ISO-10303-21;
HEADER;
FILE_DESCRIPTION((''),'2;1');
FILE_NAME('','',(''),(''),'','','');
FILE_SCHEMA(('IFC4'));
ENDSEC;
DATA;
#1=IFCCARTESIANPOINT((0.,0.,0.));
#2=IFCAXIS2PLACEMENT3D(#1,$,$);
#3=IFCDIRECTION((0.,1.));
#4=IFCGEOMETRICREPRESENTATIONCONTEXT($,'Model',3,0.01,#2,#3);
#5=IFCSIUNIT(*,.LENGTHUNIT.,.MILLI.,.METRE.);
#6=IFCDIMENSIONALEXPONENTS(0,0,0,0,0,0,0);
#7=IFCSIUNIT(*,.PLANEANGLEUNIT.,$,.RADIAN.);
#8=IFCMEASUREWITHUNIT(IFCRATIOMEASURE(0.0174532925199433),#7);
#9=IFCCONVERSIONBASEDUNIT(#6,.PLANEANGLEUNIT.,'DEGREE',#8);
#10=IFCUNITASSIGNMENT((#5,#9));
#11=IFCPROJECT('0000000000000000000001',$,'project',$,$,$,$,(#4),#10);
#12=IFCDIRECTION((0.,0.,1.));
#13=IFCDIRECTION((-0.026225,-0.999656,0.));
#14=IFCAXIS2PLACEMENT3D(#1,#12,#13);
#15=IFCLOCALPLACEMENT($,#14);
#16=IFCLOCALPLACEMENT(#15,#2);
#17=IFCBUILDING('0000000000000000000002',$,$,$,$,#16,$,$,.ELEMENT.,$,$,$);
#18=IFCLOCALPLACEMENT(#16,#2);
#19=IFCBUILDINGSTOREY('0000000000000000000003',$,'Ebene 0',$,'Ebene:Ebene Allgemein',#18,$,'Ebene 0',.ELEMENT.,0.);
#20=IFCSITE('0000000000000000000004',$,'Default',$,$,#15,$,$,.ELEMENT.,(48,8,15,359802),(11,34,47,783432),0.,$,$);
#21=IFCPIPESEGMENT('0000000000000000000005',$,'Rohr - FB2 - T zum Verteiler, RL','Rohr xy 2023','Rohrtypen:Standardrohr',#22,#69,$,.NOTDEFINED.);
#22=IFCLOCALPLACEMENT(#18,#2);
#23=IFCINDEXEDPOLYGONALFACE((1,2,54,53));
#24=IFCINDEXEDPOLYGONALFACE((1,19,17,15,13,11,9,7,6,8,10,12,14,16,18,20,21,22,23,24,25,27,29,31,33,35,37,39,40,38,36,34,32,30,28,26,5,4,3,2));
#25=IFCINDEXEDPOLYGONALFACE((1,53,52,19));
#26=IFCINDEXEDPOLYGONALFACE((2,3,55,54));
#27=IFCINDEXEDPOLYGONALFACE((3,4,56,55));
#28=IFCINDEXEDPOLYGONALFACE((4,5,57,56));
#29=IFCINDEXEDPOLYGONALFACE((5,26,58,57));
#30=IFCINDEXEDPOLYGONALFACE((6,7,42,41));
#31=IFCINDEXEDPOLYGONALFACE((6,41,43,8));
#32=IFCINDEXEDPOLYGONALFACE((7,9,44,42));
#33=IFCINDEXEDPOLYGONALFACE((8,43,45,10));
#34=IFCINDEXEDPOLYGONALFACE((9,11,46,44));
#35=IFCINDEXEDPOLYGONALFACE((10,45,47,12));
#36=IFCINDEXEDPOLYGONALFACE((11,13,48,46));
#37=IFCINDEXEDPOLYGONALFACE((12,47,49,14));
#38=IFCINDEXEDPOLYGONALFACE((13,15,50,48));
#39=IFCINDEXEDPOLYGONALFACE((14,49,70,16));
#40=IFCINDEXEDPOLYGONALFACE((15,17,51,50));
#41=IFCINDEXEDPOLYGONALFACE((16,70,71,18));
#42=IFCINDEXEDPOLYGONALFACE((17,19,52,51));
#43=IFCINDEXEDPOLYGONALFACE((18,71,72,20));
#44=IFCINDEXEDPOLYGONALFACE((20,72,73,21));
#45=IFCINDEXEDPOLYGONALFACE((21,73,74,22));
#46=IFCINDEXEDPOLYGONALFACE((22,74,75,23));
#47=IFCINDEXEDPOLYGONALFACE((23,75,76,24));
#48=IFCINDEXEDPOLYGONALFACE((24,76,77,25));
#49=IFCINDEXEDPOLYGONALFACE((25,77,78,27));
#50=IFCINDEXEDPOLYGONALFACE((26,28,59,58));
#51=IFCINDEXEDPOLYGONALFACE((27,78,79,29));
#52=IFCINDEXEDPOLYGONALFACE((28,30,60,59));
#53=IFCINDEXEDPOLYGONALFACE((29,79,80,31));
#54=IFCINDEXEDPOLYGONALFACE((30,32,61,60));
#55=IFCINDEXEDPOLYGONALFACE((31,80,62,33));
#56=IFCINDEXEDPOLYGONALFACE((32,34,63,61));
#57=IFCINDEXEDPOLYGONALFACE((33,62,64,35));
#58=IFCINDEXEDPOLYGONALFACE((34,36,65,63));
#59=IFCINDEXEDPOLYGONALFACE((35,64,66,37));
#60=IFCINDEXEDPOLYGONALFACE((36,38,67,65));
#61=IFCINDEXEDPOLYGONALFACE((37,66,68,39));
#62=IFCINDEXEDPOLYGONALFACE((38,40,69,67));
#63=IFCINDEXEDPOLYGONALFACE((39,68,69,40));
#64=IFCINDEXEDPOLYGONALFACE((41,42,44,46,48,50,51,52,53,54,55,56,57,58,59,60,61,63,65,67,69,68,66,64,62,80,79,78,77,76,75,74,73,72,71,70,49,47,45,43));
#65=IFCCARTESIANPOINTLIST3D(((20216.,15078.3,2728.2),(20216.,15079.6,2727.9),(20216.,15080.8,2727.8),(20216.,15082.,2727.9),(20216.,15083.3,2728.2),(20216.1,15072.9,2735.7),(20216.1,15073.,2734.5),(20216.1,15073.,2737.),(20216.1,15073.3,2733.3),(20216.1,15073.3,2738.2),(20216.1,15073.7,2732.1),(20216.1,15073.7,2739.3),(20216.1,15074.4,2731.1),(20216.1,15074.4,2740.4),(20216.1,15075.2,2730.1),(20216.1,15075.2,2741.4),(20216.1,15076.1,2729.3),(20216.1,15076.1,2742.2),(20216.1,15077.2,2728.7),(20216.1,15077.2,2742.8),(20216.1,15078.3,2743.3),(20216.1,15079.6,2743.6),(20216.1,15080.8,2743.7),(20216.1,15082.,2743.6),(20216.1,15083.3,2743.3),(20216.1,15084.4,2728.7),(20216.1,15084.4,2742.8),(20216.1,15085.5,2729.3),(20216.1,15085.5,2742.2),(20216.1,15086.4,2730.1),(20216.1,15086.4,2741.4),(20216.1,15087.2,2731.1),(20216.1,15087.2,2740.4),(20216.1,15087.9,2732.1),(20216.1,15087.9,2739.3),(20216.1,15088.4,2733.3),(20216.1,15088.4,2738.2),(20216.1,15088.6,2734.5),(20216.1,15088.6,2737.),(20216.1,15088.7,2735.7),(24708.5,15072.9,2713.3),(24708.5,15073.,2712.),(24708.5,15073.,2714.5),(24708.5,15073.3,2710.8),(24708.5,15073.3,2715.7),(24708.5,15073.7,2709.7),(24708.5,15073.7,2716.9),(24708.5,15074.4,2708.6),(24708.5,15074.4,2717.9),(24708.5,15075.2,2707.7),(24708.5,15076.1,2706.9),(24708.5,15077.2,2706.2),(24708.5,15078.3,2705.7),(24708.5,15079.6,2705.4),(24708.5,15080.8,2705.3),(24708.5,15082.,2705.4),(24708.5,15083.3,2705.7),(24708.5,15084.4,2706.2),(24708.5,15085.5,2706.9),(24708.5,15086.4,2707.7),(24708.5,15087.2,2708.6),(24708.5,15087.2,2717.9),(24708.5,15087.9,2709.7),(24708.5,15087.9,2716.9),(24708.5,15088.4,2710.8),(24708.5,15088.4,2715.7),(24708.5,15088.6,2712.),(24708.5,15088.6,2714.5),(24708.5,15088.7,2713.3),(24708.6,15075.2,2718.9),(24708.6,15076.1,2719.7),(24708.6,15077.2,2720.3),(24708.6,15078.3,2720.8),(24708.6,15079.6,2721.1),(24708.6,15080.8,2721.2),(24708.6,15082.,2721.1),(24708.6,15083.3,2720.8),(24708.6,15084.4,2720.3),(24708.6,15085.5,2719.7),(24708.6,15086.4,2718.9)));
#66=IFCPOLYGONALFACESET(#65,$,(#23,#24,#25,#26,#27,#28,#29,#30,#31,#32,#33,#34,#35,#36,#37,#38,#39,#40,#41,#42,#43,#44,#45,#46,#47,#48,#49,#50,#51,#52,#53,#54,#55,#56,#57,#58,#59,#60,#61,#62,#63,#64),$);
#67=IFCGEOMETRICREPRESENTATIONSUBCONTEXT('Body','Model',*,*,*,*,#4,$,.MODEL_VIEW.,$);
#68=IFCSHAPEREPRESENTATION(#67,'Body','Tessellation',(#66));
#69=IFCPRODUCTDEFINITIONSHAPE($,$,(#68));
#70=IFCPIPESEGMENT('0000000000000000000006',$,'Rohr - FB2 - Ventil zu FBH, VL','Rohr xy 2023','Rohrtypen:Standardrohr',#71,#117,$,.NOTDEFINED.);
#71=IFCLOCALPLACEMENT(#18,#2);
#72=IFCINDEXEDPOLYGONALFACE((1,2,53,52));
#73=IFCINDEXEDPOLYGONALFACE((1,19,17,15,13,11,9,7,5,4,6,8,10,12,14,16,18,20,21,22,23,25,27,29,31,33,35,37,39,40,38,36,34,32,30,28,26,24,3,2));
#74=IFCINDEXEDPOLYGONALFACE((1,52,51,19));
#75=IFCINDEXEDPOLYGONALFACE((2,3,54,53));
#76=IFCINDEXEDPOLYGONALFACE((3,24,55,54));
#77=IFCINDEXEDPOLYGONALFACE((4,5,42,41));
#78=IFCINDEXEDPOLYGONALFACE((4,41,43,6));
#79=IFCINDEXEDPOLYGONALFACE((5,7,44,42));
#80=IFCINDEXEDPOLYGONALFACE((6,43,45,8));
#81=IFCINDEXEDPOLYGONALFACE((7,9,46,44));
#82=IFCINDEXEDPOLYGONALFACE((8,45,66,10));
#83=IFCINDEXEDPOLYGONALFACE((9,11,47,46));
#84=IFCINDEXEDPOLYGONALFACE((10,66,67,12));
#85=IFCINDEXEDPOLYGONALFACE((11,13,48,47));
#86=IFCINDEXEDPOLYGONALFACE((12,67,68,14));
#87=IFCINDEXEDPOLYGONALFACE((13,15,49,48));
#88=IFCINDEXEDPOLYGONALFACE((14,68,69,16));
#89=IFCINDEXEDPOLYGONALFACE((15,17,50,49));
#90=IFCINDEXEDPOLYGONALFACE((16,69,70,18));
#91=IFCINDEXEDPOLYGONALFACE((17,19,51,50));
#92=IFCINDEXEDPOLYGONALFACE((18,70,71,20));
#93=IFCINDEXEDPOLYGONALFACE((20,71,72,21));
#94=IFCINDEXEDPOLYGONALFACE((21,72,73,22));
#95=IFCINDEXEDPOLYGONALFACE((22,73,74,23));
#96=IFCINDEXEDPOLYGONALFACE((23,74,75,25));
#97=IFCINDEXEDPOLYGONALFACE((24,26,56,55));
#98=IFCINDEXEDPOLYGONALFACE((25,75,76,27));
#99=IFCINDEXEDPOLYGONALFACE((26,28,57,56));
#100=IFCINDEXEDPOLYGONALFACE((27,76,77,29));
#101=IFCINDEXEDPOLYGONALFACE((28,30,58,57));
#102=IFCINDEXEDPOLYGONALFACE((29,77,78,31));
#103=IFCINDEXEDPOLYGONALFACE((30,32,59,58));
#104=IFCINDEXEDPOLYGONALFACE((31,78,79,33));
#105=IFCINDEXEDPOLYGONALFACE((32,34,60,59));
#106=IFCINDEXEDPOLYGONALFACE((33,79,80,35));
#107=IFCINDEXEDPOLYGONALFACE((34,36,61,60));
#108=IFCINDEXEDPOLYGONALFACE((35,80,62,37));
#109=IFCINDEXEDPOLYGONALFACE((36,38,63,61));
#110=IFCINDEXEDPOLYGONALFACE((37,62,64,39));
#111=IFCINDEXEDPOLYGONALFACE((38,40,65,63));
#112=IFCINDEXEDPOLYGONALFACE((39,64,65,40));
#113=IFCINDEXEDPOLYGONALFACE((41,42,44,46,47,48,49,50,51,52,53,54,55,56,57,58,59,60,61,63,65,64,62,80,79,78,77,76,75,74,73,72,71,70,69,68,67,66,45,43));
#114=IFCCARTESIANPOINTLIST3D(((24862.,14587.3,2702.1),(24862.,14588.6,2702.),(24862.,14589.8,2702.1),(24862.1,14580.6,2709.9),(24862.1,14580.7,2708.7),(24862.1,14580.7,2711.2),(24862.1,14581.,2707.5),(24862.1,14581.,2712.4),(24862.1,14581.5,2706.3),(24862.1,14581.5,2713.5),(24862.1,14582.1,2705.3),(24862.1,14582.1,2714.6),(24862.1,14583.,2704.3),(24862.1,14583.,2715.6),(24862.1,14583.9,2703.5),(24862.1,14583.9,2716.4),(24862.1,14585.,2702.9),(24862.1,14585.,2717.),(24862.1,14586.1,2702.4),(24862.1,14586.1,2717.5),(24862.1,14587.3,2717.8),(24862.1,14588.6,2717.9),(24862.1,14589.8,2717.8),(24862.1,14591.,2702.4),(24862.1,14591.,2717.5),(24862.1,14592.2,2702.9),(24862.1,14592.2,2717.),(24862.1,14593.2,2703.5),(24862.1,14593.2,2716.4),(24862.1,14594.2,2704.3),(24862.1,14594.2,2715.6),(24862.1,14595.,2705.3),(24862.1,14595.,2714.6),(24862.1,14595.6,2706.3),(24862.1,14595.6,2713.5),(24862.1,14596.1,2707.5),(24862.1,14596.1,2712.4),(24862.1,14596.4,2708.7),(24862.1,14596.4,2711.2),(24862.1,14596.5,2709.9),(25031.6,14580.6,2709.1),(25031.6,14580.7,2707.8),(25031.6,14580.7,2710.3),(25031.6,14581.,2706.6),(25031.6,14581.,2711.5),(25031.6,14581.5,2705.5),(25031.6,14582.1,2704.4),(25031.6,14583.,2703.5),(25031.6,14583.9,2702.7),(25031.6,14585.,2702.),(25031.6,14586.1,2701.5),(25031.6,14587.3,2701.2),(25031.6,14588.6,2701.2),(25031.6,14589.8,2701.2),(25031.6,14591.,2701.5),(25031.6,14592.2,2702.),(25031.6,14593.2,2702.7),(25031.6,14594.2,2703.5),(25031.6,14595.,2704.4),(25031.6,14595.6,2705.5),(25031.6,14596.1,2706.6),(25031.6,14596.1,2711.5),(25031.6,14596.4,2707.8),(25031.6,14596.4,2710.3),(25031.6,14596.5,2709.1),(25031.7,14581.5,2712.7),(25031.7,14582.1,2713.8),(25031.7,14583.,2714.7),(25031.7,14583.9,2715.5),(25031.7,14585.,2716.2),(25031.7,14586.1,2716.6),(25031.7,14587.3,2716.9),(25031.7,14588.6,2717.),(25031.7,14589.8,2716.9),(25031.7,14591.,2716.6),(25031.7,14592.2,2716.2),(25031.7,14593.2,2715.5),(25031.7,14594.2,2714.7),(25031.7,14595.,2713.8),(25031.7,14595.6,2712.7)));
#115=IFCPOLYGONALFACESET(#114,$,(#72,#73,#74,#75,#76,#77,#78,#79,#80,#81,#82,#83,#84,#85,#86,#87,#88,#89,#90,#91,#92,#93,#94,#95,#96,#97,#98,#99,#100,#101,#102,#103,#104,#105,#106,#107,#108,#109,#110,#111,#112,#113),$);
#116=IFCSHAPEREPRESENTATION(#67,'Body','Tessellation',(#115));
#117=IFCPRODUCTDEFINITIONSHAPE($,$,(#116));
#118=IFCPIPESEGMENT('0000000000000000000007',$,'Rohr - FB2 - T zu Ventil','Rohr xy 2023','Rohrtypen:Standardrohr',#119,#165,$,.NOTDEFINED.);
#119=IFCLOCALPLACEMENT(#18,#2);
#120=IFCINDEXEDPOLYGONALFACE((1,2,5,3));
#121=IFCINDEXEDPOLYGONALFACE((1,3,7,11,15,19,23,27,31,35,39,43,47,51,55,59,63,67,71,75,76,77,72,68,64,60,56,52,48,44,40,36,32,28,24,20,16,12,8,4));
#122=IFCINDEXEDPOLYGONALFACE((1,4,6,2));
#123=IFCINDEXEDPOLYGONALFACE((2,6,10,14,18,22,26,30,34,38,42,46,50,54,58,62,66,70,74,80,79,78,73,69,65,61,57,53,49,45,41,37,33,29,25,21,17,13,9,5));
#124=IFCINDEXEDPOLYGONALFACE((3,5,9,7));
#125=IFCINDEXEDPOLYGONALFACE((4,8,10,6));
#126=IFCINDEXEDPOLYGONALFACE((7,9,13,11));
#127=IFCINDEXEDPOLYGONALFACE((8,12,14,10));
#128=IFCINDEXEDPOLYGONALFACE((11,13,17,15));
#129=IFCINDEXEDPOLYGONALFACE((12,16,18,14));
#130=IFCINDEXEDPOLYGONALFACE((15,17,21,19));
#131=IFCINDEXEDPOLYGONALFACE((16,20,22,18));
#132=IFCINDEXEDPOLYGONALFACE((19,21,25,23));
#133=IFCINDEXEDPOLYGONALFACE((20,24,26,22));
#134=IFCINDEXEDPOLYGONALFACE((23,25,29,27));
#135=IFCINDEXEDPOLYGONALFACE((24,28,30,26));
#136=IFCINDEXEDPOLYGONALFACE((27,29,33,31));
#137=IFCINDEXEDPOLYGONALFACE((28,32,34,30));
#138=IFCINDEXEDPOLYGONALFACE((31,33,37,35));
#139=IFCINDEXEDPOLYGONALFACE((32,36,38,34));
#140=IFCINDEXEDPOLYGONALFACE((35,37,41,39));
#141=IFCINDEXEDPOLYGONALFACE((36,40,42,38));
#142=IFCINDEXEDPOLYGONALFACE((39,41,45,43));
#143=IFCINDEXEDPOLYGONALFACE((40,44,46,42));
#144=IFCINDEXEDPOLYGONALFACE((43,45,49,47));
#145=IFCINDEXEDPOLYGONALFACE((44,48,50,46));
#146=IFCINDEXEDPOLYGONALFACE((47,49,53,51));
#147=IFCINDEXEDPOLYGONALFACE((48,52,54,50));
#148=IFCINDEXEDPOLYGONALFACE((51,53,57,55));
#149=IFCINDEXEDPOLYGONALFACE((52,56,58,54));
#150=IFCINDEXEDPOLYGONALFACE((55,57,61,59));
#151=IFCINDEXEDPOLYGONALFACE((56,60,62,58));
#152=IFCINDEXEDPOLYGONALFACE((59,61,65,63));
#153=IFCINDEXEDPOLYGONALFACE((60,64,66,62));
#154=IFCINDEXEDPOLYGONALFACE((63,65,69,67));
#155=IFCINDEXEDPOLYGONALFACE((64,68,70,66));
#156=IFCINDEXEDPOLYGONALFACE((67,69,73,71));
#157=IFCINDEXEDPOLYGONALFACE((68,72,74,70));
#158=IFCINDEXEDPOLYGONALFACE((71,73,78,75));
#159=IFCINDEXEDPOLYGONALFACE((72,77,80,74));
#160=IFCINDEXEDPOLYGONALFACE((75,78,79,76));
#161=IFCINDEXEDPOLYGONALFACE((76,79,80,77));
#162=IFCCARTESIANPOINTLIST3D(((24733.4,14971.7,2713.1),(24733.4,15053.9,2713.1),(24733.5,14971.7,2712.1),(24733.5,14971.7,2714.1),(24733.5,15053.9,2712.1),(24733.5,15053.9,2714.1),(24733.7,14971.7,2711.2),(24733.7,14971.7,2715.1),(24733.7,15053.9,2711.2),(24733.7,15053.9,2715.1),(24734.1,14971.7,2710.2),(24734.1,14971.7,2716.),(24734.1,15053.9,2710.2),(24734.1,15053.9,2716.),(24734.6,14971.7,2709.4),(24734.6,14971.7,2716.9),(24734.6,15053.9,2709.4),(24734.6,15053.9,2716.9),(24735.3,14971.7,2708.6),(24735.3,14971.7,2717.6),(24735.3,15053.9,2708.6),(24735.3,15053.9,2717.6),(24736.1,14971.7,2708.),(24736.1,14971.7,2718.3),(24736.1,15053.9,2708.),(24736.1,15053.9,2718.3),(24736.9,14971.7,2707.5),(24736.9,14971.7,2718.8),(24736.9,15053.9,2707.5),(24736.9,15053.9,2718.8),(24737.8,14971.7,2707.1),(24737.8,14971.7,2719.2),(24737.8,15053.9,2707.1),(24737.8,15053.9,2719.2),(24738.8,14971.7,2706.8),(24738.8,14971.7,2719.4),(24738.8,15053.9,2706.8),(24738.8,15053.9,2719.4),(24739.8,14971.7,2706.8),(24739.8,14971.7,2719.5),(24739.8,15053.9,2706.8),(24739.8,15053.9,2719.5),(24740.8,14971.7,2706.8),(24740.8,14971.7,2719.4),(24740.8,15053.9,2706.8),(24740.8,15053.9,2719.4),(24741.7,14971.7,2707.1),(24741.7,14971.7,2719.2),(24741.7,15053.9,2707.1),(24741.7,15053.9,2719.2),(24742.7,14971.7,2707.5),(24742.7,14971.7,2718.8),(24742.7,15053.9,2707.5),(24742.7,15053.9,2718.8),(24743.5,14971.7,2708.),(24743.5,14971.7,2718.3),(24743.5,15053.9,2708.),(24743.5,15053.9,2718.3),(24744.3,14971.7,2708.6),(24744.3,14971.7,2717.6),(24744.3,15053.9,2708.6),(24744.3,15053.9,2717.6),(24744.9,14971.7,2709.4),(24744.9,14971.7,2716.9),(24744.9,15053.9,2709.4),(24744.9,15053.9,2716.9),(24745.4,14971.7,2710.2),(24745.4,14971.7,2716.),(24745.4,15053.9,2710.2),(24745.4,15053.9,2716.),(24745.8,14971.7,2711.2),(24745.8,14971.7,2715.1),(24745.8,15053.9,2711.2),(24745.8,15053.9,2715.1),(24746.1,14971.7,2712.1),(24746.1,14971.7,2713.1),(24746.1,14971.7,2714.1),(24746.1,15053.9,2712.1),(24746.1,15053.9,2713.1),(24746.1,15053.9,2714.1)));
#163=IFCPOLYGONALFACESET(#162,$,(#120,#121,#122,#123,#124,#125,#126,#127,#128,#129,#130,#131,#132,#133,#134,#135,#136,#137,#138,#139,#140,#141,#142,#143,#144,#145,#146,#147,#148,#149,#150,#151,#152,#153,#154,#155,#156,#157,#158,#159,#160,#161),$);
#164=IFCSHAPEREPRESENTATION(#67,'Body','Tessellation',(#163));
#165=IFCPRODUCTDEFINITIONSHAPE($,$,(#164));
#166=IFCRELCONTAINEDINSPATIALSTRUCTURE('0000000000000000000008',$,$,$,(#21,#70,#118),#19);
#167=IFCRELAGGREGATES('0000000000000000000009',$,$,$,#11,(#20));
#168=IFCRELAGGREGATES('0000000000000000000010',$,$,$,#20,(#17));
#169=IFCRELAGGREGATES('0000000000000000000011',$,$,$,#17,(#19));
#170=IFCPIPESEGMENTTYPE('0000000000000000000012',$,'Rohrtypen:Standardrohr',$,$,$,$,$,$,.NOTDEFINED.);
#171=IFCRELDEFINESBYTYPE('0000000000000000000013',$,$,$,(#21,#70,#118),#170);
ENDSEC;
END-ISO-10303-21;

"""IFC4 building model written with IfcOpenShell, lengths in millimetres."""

from ifc_helpers import new_model, entity, si_unit, converted_unit, direction, frame, origin, place, context, subcontext, project, spatial, indexed_curve, outline, extrude, type_object, element, save


model = new_model("IFC4")

# Units and contexts
model_context = context("Model", 3, precision=0.01, world=origin(), true_north=direction((0.0, 1.0)))
body_context = subcontext(model_context, "Body", "Model", "MODEL_VIEW")
ifc_project = project(units=[si_unit("LENGTHUNIT", "METRE", prefix="MILLI"), converted_unit("PLANEANGLEUNIT", "DEGREE", entity("IfcRatioMeasure", 0.0174532925199433), si_unit("PLANEANGLEUNIT", "RADIAN"), dimensions=[0, 0, 0, 0, 0, 0, 0])], contexts=[model_context])

# Site, building, storey
site_placement = place(None, frame((0.0, 0.0, 0.0), z_axis=(0.0, 0.0, 1.0), x_axis=(-0.026225, -0.999656, 0.0)))
site = spatial("IfcSite", under=ifc_project, at=site_placement, Name="Default", CompositionType="ELEMENT", RefLatitude=(48, 8, 15, 359802), RefLongitude=(11, 34, 47, 783432), RefElevation=0.0)
building_placement = place(site_placement, origin())
building = spatial("IfcBuilding", under=site, at=building_placement, CompositionType="ELEMENT")
storey_placement = place(building_placement, origin())
storey = spatial("IfcBuildingStorey", under=building, at=storey_placement, Name="Ebene 0", ObjectType="Ebene:Ebene Allgemein", LongName="Ebene 0", CompositionType="ELEMENT", Elevation=0.0)

# Pipe segments
pipe_segment_type = type_object("IfcPipeSegmentType", Name="Rohrtypen:Standardrohr", PredefinedType="NOTDEFINED")
pipe_segment_1_placement = place(storey_placement, origin())
element("IfcPipeSegment", 1, at=pipe_segment_1_placement, inside=storey, type_object=pipe_segment_type, Name="Rohr - FB2 - T zum Verteiler, RL", Description="Rohr xy 2023", ObjectType="Rohrtypen:Standardrohr", PredefinedType="NOTDEFINED", context=body_context, shape_type="SweptSolid", body=[
    extrude(outline(indexed_curve([(7.9, 0.0), (7.8, 1.2), (7.6, 2.5), (7.1, 3.6), (6.4, 4.7), (5.6, 5.6), (4.7, 6.4), (3.6, 7.1), (2.5, 7.6), (1.2, 7.8), (0.0, 7.9), (-1.2, 7.8), (-2.5, 7.6), (-3.6, 7.1), (-4.7, 6.4), (-5.6, 5.6), (-6.4, 4.7), (-7.1, 3.6), (-7.6, 2.5), (-7.8, 1.2), (-7.9, 0.0), (-7.8, -1.2), (-7.6, -2.5), (-7.1, -3.6), (-6.4, -4.7), (-5.6, -5.6), (-4.7, -6.4), (-3.6, -7.1), (-2.5, -7.6), (-1.2, -7.8), (0.0, -7.9), (1.2, -7.8), (2.5, -7.6), (3.6, -7.1), (4.7, -6.4), (5.6, -5.6), (6.4, -4.7), (7.1, -3.6), (7.6, -2.5), (7.8, -1.2), (7.9, 0.0)], self_intersect=False)), frame((24708.5, 15080.8, 2713.3), z_axis=(-0.999988, 0.0, 0.005), x_axis=(0.0, 1.0, 0.0)), (0.0, 0.0, 1.0), 4492.5),
])
pipe_segment_2_placement = place(storey_placement, origin())
element("IfcPipeSegment", 2, at=pipe_segment_2_placement, inside=storey, type_object=pipe_segment_type, Name="Rohr - FB2 - Ventil zu FBH, VL", Description="Rohr xy 2023", ObjectType="Rohrtypen:Standardrohr", PredefinedType="NOTDEFINED", context=body_context, shape_type="SweptSolid", body=[
    extrude(outline(indexed_curve([(7.9, 0.0), (7.8, 1.2), (7.6, 2.5), (7.1, 3.6), (6.4, 4.7), (5.6, 5.6), (4.7, 6.4), (3.6, 7.1), (2.5, 7.6), (1.2, 7.8), (0.0, 7.9), (-1.2, 7.8), (-2.5, 7.6), (-3.6, 7.1), (-4.7, 6.4), (-5.6, 5.6), (-6.4, 4.7), (-7.1, 3.6), (-7.6, 2.5), (-7.8, 1.2), (-7.9, 0.0), (-7.8, -1.2), (-7.6, -2.5), (-7.1, -3.6), (-6.4, -4.7), (-5.6, -5.6), (-4.7, -6.4), (-3.6, -7.1), (-2.5, -7.6), (-1.2, -7.8), (0.0, -7.9), (1.2, -7.8), (2.5, -7.6), (3.6, -7.1), (4.7, -6.4), (5.6, -5.6), (6.4, -4.7), (7.1, -3.6), (7.6, -2.5), (7.8, -1.2), (7.9, 0.0)], self_intersect=False)), frame((24862.1, 14588.6, 2709.9), z_axis=(0.999988, 0.0, -0.005), x_axis=(0.0, 1.0, 0.0)), (0.0, 0.0, 1.0), 169.5),
])
pipe_segment_3_placement = place(storey_placement, origin())
element("IfcPipeSegment", 3, at=pipe_segment_3_placement, inside=storey, type_object=pipe_segment_type, Name="Rohr - FB2 - T zu Ventil", Description="Rohr xy 2023", ObjectType="Rohrtypen:Standardrohr", PredefinedType="NOTDEFINED", context=body_context, shape_type="SweptSolid", body=[
    extrude(outline(indexed_curve([(6.3, 0.0), (6.3, 1.0), (6.0, 2.0), (5.7, 2.9), (5.1, 3.7), (4.5, 4.5), (3.7, 5.1), (2.9, 5.7), (2.0, 6.0), (1.0, 6.3), (0.0, 6.4), (-1.0, 6.3), (-2.0, 6.0), (-2.9, 5.7), (-3.7, 5.1), (-4.5, 4.5), (-5.1, 3.7), (-5.7, 2.9), (-6.0, 2.0), (-6.3, 1.0), (-6.3, 0.0), (-6.3, -1.0), (-6.0, -2.0), (-5.7, -2.9), (-5.1, -3.7), (-4.5, -4.5), (-3.7, -5.1), (-2.9, -5.7), (-2.0, -6.0), (-1.0, -6.3), (0.0, -6.4), (1.0, -6.3), (2.0, -6.0), (2.9, -5.7), (3.7, -5.1), (4.5, -4.5), (5.1, -3.7), (5.7, -2.9), (6.0, -2.0), (6.3, -1.0), (6.3, 0.0)], self_intersect=False)), frame((24739.8, 14971.7, 2713.1), z_axis=(0.0, 1.0, 0.0), x_axis=(-1.0, 0.0, 0.0)), (0.0, 0.0, 1.0), 82.2),
])

save(model, "model.ifc")
